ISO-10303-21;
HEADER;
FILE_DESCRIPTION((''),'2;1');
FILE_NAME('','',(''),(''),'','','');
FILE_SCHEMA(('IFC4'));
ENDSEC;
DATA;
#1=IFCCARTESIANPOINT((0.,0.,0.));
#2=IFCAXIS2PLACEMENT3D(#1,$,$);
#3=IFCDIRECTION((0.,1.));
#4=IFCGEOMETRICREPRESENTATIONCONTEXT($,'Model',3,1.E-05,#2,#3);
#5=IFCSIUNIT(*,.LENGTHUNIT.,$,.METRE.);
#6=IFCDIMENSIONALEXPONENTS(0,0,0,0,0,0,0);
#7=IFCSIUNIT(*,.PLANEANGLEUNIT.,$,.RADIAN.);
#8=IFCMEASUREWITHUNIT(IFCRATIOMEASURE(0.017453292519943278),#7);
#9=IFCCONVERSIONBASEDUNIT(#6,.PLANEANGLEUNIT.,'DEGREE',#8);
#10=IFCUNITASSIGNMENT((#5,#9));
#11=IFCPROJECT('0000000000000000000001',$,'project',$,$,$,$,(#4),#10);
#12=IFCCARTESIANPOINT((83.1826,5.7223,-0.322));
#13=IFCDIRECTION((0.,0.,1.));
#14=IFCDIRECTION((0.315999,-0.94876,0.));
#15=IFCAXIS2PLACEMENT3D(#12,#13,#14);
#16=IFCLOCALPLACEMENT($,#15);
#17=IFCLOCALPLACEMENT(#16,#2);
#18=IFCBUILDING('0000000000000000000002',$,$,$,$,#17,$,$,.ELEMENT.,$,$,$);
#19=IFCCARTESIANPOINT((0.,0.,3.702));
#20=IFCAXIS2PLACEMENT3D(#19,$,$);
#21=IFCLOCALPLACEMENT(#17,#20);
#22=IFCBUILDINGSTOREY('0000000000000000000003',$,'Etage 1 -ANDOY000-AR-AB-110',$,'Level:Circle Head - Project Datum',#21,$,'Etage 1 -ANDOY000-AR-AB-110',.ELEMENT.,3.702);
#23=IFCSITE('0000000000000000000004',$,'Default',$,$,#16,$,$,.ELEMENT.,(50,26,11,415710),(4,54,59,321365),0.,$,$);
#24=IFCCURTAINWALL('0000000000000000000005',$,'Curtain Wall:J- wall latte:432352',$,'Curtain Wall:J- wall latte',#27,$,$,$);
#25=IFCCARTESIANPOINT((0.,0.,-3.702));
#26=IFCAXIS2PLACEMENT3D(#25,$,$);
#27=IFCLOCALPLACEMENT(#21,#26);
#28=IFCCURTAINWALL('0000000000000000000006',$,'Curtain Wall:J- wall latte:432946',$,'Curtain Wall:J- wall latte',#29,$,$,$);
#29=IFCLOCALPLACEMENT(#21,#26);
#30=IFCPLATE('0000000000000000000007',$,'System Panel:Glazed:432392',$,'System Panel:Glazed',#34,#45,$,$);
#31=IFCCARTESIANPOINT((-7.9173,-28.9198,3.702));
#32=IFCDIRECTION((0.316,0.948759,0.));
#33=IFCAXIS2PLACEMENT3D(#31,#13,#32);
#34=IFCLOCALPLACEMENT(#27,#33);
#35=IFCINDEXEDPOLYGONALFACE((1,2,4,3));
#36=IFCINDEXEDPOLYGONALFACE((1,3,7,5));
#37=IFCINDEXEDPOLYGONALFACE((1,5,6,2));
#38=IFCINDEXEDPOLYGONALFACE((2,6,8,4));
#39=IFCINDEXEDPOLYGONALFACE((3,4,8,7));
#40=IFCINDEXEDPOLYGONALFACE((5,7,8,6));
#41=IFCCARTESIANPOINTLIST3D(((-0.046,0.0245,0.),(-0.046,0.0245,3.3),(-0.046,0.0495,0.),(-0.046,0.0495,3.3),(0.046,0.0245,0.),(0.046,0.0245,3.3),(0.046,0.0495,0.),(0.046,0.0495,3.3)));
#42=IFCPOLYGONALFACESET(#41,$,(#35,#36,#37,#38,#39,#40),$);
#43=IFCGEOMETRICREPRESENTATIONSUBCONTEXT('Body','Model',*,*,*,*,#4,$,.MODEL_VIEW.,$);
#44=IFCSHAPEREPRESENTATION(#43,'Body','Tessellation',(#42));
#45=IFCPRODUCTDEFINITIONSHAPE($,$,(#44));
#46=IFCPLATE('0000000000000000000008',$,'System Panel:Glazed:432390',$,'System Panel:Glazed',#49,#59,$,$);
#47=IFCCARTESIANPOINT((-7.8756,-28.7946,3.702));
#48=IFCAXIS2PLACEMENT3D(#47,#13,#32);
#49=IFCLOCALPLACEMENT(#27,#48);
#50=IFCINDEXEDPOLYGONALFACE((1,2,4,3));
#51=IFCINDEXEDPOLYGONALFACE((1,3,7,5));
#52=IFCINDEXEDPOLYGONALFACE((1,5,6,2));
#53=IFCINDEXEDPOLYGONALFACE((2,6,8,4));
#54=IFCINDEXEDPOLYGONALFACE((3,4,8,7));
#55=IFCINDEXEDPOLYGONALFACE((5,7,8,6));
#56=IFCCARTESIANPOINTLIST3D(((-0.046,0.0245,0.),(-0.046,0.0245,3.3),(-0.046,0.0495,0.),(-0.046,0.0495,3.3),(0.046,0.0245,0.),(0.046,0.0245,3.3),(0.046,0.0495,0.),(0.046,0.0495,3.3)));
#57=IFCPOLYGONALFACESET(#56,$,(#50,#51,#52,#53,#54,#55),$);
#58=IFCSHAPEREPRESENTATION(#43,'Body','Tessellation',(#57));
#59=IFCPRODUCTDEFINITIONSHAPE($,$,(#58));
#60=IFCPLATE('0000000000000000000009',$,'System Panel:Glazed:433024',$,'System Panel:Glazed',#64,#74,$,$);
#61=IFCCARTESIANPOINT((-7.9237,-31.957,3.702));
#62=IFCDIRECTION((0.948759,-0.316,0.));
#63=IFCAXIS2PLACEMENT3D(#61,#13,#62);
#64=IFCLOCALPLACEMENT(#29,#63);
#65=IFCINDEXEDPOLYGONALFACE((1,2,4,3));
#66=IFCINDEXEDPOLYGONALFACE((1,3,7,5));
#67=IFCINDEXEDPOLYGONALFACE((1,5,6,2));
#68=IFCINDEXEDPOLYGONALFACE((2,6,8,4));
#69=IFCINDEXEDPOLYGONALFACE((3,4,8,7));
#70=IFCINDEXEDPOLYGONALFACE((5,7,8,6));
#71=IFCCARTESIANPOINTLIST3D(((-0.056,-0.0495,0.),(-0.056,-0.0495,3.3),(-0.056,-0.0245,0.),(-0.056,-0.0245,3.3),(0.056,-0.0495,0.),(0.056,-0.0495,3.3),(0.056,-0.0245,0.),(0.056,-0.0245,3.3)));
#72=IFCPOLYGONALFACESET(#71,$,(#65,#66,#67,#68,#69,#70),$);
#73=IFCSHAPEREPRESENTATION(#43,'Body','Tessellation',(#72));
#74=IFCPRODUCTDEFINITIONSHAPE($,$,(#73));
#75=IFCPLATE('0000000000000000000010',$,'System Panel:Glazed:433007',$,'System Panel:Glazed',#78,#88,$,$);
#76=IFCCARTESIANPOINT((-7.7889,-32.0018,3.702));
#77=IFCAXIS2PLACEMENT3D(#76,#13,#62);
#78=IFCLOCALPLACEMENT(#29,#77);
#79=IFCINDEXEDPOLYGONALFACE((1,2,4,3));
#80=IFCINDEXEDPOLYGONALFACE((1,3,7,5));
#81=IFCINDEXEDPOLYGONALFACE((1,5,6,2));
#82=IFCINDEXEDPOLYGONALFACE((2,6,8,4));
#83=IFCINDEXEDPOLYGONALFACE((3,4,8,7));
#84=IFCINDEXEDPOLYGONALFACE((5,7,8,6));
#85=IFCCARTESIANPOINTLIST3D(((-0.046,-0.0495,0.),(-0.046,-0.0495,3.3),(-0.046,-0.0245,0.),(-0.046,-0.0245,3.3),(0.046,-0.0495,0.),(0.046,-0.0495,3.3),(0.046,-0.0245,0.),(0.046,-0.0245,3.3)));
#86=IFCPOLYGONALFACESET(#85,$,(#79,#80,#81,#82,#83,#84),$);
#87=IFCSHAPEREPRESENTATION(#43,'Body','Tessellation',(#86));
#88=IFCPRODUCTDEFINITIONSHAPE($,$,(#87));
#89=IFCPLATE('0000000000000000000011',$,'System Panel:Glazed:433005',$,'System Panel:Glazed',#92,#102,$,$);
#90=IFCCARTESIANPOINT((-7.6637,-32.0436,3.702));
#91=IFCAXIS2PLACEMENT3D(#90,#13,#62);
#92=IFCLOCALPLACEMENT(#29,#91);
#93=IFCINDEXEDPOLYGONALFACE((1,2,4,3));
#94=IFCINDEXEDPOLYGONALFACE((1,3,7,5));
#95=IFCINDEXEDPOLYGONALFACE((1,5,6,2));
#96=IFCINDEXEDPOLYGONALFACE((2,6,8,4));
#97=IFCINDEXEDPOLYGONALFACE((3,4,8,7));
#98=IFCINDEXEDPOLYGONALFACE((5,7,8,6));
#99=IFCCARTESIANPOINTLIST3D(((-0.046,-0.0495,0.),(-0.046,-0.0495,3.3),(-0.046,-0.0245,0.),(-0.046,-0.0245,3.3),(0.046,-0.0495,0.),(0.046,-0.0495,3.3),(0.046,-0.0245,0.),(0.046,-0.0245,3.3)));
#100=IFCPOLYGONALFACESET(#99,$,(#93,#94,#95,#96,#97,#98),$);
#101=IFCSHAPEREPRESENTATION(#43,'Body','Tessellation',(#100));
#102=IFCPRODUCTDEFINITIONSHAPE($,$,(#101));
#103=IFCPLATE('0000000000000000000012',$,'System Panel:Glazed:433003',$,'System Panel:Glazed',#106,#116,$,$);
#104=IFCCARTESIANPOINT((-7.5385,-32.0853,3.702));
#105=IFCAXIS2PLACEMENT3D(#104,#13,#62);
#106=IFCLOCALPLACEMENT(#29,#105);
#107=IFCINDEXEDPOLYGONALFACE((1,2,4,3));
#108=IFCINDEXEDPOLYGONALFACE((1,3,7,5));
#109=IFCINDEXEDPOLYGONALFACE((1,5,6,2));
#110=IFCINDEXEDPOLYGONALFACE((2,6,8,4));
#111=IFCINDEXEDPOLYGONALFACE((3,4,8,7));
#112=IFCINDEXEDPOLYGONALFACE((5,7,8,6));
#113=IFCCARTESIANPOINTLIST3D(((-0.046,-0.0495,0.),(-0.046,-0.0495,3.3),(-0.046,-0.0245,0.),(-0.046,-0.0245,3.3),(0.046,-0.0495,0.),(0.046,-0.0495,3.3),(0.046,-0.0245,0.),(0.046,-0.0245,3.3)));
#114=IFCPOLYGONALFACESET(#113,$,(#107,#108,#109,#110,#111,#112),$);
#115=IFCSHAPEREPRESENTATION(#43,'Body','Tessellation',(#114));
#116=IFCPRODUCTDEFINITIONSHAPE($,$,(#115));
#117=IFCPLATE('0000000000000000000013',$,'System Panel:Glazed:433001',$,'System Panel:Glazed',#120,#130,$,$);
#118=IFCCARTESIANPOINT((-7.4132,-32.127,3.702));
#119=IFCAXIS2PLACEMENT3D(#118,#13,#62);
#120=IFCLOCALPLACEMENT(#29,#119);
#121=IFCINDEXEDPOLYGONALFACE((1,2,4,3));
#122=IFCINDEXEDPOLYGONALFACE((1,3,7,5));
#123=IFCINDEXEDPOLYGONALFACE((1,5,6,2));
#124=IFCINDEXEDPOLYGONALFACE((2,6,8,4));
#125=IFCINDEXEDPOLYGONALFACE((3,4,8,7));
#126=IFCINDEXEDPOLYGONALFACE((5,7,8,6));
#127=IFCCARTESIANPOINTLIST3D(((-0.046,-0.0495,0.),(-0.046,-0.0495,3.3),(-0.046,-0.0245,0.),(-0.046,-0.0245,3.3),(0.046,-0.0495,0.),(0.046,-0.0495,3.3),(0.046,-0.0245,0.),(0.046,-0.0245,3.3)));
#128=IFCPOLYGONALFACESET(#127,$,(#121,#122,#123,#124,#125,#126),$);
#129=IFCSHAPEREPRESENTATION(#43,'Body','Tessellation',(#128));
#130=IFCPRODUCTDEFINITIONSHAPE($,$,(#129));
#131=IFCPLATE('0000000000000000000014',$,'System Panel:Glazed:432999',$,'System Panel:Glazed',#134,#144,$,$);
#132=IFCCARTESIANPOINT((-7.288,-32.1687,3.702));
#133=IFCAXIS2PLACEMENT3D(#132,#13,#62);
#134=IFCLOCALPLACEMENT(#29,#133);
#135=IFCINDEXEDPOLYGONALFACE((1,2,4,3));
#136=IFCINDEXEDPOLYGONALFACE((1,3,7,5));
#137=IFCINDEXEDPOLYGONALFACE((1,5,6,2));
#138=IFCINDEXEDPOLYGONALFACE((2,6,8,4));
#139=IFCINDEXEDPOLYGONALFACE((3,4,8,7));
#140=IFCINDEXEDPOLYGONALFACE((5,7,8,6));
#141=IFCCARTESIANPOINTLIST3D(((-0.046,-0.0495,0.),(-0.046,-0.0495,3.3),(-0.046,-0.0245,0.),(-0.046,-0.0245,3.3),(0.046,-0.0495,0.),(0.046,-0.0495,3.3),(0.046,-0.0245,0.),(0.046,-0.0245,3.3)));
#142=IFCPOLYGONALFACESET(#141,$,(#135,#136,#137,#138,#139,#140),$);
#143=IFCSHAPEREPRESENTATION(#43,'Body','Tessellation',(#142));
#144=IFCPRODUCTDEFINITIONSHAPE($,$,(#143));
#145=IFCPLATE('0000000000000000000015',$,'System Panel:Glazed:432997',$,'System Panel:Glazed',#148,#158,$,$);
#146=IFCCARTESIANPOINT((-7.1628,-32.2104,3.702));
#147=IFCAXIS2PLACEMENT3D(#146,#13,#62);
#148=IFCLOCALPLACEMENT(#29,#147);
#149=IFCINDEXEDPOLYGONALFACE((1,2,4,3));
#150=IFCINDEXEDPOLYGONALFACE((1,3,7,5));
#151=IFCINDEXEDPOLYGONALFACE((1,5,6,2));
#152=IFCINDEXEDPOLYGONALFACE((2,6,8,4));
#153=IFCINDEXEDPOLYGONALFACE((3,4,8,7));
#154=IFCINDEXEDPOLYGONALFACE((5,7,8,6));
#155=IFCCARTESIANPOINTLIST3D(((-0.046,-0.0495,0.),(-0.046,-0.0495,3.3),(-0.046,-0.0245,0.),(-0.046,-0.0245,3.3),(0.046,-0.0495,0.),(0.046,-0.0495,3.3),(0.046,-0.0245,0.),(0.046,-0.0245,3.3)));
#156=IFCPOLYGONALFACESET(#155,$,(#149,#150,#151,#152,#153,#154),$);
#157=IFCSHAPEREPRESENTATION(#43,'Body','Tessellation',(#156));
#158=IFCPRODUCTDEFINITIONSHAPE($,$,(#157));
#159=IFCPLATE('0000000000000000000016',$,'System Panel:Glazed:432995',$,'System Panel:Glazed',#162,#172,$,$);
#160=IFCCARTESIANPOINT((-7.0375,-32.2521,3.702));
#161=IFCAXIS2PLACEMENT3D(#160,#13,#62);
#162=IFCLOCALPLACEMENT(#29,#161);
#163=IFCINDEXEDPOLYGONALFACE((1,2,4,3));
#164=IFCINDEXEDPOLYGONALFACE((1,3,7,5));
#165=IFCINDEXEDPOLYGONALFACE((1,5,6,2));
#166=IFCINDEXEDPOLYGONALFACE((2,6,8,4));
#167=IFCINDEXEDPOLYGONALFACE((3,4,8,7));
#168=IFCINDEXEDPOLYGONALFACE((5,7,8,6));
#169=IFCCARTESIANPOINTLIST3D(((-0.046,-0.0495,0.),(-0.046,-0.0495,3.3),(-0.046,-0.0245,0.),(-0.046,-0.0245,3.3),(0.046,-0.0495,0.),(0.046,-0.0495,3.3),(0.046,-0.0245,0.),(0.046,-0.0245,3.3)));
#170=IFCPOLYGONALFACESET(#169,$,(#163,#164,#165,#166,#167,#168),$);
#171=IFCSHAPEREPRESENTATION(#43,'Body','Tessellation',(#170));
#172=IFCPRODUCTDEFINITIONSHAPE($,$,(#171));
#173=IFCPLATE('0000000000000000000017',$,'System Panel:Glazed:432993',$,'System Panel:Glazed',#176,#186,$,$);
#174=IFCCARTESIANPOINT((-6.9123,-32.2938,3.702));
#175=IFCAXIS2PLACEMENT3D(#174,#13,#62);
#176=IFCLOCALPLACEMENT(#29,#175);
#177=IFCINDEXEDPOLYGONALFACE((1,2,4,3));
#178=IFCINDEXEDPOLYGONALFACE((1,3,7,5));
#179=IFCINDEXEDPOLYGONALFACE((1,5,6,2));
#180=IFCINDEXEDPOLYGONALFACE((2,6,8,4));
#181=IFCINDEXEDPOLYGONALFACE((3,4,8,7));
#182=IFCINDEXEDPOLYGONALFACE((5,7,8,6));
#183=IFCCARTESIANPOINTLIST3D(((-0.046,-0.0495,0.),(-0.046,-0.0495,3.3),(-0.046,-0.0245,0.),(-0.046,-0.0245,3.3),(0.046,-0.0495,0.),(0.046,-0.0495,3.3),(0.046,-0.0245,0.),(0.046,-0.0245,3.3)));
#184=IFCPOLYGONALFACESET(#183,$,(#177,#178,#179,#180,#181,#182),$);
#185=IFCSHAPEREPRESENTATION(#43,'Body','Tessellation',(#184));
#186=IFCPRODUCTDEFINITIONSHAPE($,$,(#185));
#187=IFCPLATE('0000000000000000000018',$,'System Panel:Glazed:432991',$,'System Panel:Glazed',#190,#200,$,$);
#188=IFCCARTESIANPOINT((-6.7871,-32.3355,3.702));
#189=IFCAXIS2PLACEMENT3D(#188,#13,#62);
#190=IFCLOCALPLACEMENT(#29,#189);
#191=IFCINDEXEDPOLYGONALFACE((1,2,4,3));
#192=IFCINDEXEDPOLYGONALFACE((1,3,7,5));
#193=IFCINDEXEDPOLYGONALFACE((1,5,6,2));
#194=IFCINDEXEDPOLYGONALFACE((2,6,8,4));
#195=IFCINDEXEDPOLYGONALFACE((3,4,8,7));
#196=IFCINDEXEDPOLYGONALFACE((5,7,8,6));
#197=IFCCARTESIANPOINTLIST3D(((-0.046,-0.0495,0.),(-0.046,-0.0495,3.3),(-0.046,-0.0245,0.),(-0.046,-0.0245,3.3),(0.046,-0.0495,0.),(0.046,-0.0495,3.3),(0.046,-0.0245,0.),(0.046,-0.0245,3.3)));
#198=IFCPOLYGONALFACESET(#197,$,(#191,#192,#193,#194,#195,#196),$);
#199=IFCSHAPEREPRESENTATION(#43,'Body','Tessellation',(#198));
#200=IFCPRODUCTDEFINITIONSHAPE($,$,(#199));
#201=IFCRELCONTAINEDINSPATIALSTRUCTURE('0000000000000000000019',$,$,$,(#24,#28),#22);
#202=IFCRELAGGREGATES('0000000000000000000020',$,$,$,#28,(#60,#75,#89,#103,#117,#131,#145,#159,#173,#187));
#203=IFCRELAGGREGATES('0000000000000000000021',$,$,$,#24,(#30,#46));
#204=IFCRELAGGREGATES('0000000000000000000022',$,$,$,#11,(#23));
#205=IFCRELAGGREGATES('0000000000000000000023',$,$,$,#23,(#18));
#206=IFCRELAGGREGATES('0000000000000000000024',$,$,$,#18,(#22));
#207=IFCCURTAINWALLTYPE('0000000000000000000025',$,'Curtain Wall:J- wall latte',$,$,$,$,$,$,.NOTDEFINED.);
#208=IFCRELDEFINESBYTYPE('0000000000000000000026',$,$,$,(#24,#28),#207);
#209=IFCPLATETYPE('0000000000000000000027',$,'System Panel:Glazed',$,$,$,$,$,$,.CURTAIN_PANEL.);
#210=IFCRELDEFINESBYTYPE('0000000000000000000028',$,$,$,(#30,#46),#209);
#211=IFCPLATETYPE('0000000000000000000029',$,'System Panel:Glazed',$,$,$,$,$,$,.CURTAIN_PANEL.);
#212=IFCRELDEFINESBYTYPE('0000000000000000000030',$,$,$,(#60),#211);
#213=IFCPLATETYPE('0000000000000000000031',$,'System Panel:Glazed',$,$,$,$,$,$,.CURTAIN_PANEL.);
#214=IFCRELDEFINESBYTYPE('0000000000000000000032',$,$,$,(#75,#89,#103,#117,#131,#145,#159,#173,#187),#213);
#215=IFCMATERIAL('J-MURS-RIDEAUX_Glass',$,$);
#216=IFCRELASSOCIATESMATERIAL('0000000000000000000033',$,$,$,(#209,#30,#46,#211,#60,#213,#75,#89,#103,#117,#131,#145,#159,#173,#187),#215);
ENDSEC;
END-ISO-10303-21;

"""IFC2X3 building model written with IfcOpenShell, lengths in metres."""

from ifc_helpers import new_model, entity, si_unit, converted_unit, direction, frame, frame_2d, origin, place, context, subcontext, project, spatial, rectangle, extrude, source, transform, mapped, material, type_object, type_shapes, element, aggregate, save


model = new_model("IFC2X3")

# Units and contexts
model_context = context("Model", 3, precision=1e-05, world=origin(), true_north=direction((0.0, 1.0)))
body_context = subcontext(model_context, "Body", "Model", "MODEL_VIEW")
ifc_project = project(units=[si_unit("LENGTHUNIT", "METRE"), converted_unit("PLANEANGLEUNIT", "DEGREE", entity("IfcRatioMeasure", 0.017453292519943278), si_unit("PLANEANGLEUNIT", "RADIAN"), dimensions=[0, 0, 0, 0, 0, 0, 0])], contexts=[model_context])

# Site, building, storey
site_placement = place(None, frame((83.1826, 5.7223, -0.322), z_axis=(0.0, 0.0, 1.0), x_axis=(0.315999, -0.94876, 0.0)))
site = spatial("IfcSite", under=ifc_project, at=site_placement, Name="Default", CompositionType="ELEMENT", RefLatitude=(50, 26, 11, 415710), RefLongitude=(4, 54, 59, 321365), RefElevation=0.0)
building_placement = place(site_placement, origin())
building = spatial("IfcBuilding", under=site, at=building_placement, CompositionType="ELEMENT")
storey_placement = place(building_placement, frame((0.0, 0.0, 3.702)))
storey = spatial("IfcBuildingStorey", under=building, at=storey_placement, Name="Etage 1 -ANDOY000-AR-AB-110", ObjectType="Level:Circle Head - Project Datum", LongName="Etage 1 -ANDOY000-AR-AB-110", CompositionType="ELEMENT", Elevation=3.702)

# Curtain walls
curtain_wall_type = type_object("IfcCurtainWallType", Name="Curtain Wall:J- wall latte", PredefinedType="NOTDEFINED")
curtain_wall_1_placement = place(storey_placement, frame((0.0, 0.0, -3.702)))
curtain_wall_1 = element("IfcCurtainWall", 1, at=curtain_wall_1_placement, inside=storey, type_object=curtain_wall_type, Name="Curtain Wall:J- wall latte:432352", ObjectType="Curtain Wall:J- wall latte")
curtain_wall_2_placement = place(storey_placement, frame((0.0, 0.0, -3.702)))
curtain_wall_2 = element("IfcCurtainWall", 2, at=curtain_wall_2_placement, inside=storey, type_object=curtain_wall_type, Name="Curtain Wall:J- wall latte:432946", ObjectType="Curtain Wall:J- wall latte")

# Plates
ifc_material_1 = material(Name="J-MURS-RIDEAUX_Glass")
plate_type_1 = type_object("IfcPlateType", Name="System Panel:Glazed", PredefinedType="CURTAIN_PANEL", material=ifc_material_1)
shared_shape_1 = source(origin(), body_context, "Body", "SweptSolid", [
    extrude(rectangle(XDim=0.025, YDim=0.092, at=frame_2d((0.0, 0.0), x_axis=(1.0, 0.0))), frame((0.0, 0.037, 0.0), z_axis=(0.0, 0.0, 1.0), x_axis=(0.0, 1.0, 0.0)), (0.0, 0.0, 1.0), 3.3),
])
type_shapes(plate_type_1, [shared_shape_1])
plate_1_placement = place(curtain_wall_1_placement, frame((-7.9173, -28.9198, 3.702), z_axis=(0.0, 0.0, 1.0), x_axis=(0.316, 0.948759, 0.0)))
plate_1 = element("IfcPlate", 3, at=plate_1_placement, type_object=plate_type_1, material=ifc_material_1, Name="System Panel:Glazed:432392", ObjectType="System Panel:Glazed", context=body_context, shape_type="MappedRepresentation", body=[
    mapped(shared_shape_1, transform((0.0, 0.0, 0.0), scale=1.0)),
])
plate_2_placement = place(curtain_wall_1_placement, frame((-7.8756, -28.7946, 3.702), z_axis=(0.0, 0.0, 1.0), x_axis=(0.316, 0.948759, 0.0)))
plate_2 = element("IfcPlate", 4, at=plate_2_placement, type_object=plate_type_1, material=ifc_material_1, Name="System Panel:Glazed:432390", ObjectType="System Panel:Glazed", context=body_context, shape_type="MappedRepresentation", body=[
    mapped(shared_shape_1, transform((0.0, 0.0, 0.0), scale=1.0)),
])
plate_type_2 = type_object("IfcPlateType", Name="System Panel:Glazed", PredefinedType="CURTAIN_PANEL", material=ifc_material_1)
shared_shape_2 = source(origin(), body_context, "Body", "SweptSolid", [
    extrude(rectangle(XDim=0.025, YDim=0.112, at=frame_2d((0.0, 0.0), x_axis=(1.0, 0.0))), frame((0.0, -0.037, 0.0), z_axis=(0.0, 0.0, 1.0), x_axis=(0.0, 1.0, 0.0)), (0.0, 0.0, 1.0), 3.3),
])
type_shapes(plate_type_2, [shared_shape_2])
plate_3_placement = place(curtain_wall_2_placement, frame((-7.9237, -31.957, 3.702), z_axis=(0.0, 0.0, 1.0), x_axis=(0.948759, -0.316, 0.0)))
plate_3 = element("IfcPlate", 5, at=plate_3_placement, type_object=plate_type_2, material=ifc_material_1, Name="System Panel:Glazed:433024", ObjectType="System Panel:Glazed", context=body_context, shape_type="MappedRepresentation", body=[
    mapped(shared_shape_2, transform((0.0, 0.0, 0.0), scale=1.0)),
])
plate_type_3 = type_object("IfcPlateType", Name="System Panel:Glazed", PredefinedType="CURTAIN_PANEL", material=ifc_material_1)
shared_shape_3 = source(origin(), body_context, "Body", "SweptSolid", [
    extrude(rectangle(XDim=0.025, YDim=0.092, at=frame_2d((0.0, 0.0), x_axis=(1.0, 0.0))), frame((0.0, -0.037, 0.0), z_axis=(0.0, 0.0, 1.0), x_axis=(0.0, 1.0, 0.0)), (0.0, 0.0, 1.0), 3.3),
])
type_shapes(plate_type_3, [shared_shape_3])
plate_4_placement = place(curtain_wall_2_placement, frame((-7.7889, -32.0018, 3.702), z_axis=(0.0, 0.0, 1.0), x_axis=(0.948759, -0.316, 0.0)))
plate_4 = element("IfcPlate", 6, at=plate_4_placement, type_object=plate_type_3, material=ifc_material_1, Name="System Panel:Glazed:433007", ObjectType="System Panel:Glazed", context=body_context, shape_type="MappedRepresentation", body=[
    mapped(shared_shape_3, transform((0.0, 0.0, 0.0), scale=1.0)),
])
plate_5_placement = place(curtain_wall_2_placement, frame((-7.6637, -32.0436, 3.702), z_axis=(0.0, 0.0, 1.0), x_axis=(0.948759, -0.316, 0.0)))
plate_5 = element("IfcPlate", 7, at=plate_5_placement, type_object=plate_type_3, material=ifc_material_1, Name="System Panel:Glazed:433005", ObjectType="System Panel:Glazed", context=body_context, shape_type="MappedRepresentation", body=[
    mapped(shared_shape_3, transform((0.0, 0.0, 0.0), scale=1.0)),
])
plate_6_placement = place(curtain_wall_2_placement, frame((-7.5385, -32.0853, 3.702), z_axis=(0.0, 0.0, 1.0), x_axis=(0.948759, -0.316, 0.0)))
plate_6 = element("IfcPlate", 8, at=plate_6_placement, type_object=plate_type_3, material=ifc_material_1, Name="System Panel:Glazed:433003", ObjectType="System Panel:Glazed", context=body_context, shape_type="MappedRepresentation", body=[
    mapped(shared_shape_3, transform((0.0, 0.0, 0.0), scale=1.0)),
])
plate_7_placement = place(curtain_wall_2_placement, frame((-7.4132, -32.127, 3.702), z_axis=(0.0, 0.0, 1.0), x_axis=(0.948759, -0.316, 0.0)))
plate_7 = element("IfcPlate", 9, at=plate_7_placement, type_object=plate_type_3, material=ifc_material_1, Name="System Panel:Glazed:433001", ObjectType="System Panel:Glazed", context=body_context, shape_type="MappedRepresentation", body=[
    mapped(shared_shape_3, transform((0.0, 0.0, 0.0), scale=1.0)),
])
plate_8_placement = place(curtain_wall_2_placement, frame((-7.288, -32.1687, 3.702), z_axis=(0.0, 0.0, 1.0), x_axis=(0.948759, -0.316, 0.0)))
plate_8 = element("IfcPlate", 10, at=plate_8_placement, type_object=plate_type_3, material=ifc_material_1, Name="System Panel:Glazed:432999", ObjectType="System Panel:Glazed", context=body_context, shape_type="MappedRepresentation", body=[
    mapped(shared_shape_3, transform((0.0, 0.0, 0.0), scale=1.0)),
])
plate_9_placement = place(curtain_wall_2_placement, frame((-7.1628, -32.2104, 3.702), z_axis=(0.0, 0.0, 1.0), x_axis=(0.948759, -0.316, 0.0)))
plate_9 = element("IfcPlate", 11, at=plate_9_placement, type_object=plate_type_3, material=ifc_material_1, Name="System Panel:Glazed:432997", ObjectType="System Panel:Glazed", context=body_context, shape_type="MappedRepresentation", body=[
    mapped(shared_shape_3, transform((0.0, 0.0, 0.0), scale=1.0)),
])
plate_10_placement = place(curtain_wall_2_placement, frame((-7.0375, -32.2521, 3.702), z_axis=(0.0, 0.0, 1.0), x_axis=(0.948759, -0.316, 0.0)))
plate_10 = element("IfcPlate", 12, at=plate_10_placement, type_object=plate_type_3, material=ifc_material_1, Name="System Panel:Glazed:432995", ObjectType="System Panel:Glazed", context=body_context, shape_type="MappedRepresentation", body=[
    mapped(shared_shape_3, transform((0.0, 0.0, 0.0), scale=1.0)),
])
plate_11_placement = place(curtain_wall_2_placement, frame((-6.9123, -32.2938, 3.702), z_axis=(0.0, 0.0, 1.0), x_axis=(0.948759, -0.316, 0.0)))
plate_11 = element("IfcPlate", 13, at=plate_11_placement, type_object=plate_type_3, material=ifc_material_1, Name="System Panel:Glazed:432993", ObjectType="System Panel:Glazed", context=body_context, shape_type="MappedRepresentation", body=[
    mapped(shared_shape_3, transform((0.0, 0.0, 0.0), scale=1.0)),
])
plate_12_placement = place(curtain_wall_2_placement, frame((-6.7871, -32.3355, 3.702), z_axis=(0.0, 0.0, 1.0), x_axis=(0.948759, -0.316, 0.0)))
plate_12 = element("IfcPlate", 14, at=plate_12_placement, type_object=plate_type_3, material=ifc_material_1, Name="System Panel:Glazed:432991", ObjectType="System Panel:Glazed", context=body_context, shape_type="MappedRepresentation", body=[
    mapped(shared_shape_3, transform((0.0, 0.0, 0.0), scale=1.0)),
])
aggregate(curtain_wall_2, [plate_3, plate_4, plate_5, plate_6, plate_7, plate_8, plate_9, plate_10, plate_11, plate_12])
aggregate(curtain_wall_1, [plate_1, plate_2])

save(model, "model.ifc")
